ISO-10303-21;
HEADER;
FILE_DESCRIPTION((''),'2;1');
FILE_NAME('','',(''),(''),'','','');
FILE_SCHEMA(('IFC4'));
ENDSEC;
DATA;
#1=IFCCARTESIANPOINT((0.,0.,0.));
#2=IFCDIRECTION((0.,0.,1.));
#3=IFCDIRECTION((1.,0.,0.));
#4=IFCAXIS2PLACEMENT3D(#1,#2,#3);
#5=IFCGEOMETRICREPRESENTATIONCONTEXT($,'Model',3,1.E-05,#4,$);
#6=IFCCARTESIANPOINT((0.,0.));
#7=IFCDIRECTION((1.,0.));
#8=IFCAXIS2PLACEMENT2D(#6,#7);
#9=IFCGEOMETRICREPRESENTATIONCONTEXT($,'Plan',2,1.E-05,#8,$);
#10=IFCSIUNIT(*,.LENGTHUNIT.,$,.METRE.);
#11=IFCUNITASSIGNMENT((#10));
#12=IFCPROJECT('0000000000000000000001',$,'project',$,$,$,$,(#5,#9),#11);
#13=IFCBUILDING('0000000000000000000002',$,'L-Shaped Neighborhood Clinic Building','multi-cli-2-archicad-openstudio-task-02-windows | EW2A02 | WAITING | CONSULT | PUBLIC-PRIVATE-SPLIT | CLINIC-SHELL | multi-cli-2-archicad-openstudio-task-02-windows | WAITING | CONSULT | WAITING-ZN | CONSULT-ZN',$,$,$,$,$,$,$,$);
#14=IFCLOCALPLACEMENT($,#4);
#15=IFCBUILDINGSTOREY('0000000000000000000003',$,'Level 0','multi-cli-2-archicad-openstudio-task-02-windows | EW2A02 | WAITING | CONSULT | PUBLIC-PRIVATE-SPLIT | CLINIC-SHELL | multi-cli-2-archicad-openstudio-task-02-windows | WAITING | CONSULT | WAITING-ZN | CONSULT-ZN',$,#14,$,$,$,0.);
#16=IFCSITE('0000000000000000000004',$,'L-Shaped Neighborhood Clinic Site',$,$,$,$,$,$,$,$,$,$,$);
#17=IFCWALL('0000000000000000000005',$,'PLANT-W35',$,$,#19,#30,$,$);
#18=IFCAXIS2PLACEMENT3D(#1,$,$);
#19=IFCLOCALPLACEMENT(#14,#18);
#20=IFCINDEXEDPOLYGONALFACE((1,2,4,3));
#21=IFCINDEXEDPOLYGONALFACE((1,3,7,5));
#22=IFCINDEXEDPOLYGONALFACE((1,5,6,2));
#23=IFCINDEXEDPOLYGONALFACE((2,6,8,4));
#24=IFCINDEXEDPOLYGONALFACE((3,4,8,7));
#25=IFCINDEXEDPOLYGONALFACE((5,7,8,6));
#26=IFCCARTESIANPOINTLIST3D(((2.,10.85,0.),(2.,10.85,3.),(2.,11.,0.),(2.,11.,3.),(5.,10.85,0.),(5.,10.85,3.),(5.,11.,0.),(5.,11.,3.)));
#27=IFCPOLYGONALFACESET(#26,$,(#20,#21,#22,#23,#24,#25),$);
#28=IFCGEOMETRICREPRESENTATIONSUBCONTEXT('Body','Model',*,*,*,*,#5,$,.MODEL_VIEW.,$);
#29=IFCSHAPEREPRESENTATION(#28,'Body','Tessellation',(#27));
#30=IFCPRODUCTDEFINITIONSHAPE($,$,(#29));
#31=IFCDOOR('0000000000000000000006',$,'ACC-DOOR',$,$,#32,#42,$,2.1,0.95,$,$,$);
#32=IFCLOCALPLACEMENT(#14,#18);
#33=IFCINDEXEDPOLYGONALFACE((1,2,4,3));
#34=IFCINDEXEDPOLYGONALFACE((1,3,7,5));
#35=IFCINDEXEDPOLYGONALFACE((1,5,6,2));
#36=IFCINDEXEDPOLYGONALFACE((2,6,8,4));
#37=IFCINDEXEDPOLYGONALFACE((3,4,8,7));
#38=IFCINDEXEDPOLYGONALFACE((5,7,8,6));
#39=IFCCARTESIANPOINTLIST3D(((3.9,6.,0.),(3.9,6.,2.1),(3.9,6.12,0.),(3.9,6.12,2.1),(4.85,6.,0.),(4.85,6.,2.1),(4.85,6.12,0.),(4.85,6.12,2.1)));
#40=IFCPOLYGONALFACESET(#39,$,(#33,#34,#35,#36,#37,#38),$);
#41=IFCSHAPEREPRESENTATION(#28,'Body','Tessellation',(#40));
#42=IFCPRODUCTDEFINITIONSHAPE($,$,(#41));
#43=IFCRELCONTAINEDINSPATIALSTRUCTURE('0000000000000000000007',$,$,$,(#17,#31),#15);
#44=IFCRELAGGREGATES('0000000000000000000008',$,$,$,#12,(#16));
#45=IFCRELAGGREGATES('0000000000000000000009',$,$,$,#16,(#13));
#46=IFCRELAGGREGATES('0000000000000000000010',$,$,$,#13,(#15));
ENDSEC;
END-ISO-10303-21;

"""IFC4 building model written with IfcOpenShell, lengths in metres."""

from ifc_helpers import new_model, si_unit, frame, origin_with_axes, origin_2d_with_axis, place, context, subcontext, project, spatial, polyline, indexed_curve, outline, extrude, element, save


model = new_model("IFC4")

# Units and contexts
model_context = context("Model", 3, precision=1e-05, world=origin_with_axes())
plan_context = context("Plan", 2, precision=1e-05, world=origin_2d_with_axis())
body_context = subcontext(model_context, "Body", "Model", "MODEL_VIEW")
ifc_project = project(units=[si_unit("LENGTHUNIT", "METRE")], contexts=[model_context, plan_context])

# Site, building, storey
site = spatial("IfcSite", under=ifc_project, Name="L-Shaped Neighborhood Clinic Site")
building = spatial("IfcBuilding", under=site, Name="L-Shaped Neighborhood Clinic Building", Description="multi-cli-2-archicad-openstudio-task-02-windows | EW2A02 | WAITING | CONSULT | PUBLIC-PRIVATE-SPLIT | CLINIC-SHELL | multi-cli-2-archicad-openstudio-task-02-windows | WAITING | CONSULT | WAITING-ZN | CONSULT-ZN")
storey_placement = place(None, origin_with_axes())
storey = spatial("IfcBuildingStorey", under=building, at=storey_placement, Name="Level 0", Description="multi-cli-2-archicad-openstudio-task-02-windows | EW2A02 | WAITING | CONSULT | PUBLIC-PRIVATE-SPLIT | CLINIC-SHELL | multi-cli-2-archicad-openstudio-task-02-windows | WAITING | CONSULT | WAITING-ZN | CONSULT-ZN", Elevation=0.0)

# Wall
wall_1_placement = place(storey_placement, frame((5.0, 11.0, 0.0), z_axis=(0.0, 0.0, 1.0), x_axis=(-1.0, 0.0, 0.0)))
element("IfcWall", 1, at=wall_1_placement, inside=storey, Name="PLANT-W35", context=body_context, shape_type="SweptSolid", body=[
    extrude(outline(indexed_curve([(0.0, 0.0), (0.0, 0.15), (3.0, 0.15), (3.0, 0.0), (0.0, 0.0)], self_intersect=False)), origin_with_axes(), (0.0, 0.0, 1.0), 3.0),
])

# Door
door_placement = place(storey_placement, frame((3.9, 6.0, 0.0), z_axis=(0.0, 0.0, 1.0), x_axis=(1.0, 0.0, 0.0)))
element("IfcDoor", 2, at=door_placement, inside=storey, Name="ACC-DOOR", OverallHeight=2.1, OverallWidth=0.95, context=body_context, shape_type="SweptSolid", body=[
    extrude(outline(polyline([(0.0, 0.0), (0.95, 0.0), (0.95, 0.12), (0.0, 0.12), (0.0, 0.0)])), origin_with_axes(), (0.0, 0.0, 1.0), 2.1),
])

save(model, "model.ifc")
